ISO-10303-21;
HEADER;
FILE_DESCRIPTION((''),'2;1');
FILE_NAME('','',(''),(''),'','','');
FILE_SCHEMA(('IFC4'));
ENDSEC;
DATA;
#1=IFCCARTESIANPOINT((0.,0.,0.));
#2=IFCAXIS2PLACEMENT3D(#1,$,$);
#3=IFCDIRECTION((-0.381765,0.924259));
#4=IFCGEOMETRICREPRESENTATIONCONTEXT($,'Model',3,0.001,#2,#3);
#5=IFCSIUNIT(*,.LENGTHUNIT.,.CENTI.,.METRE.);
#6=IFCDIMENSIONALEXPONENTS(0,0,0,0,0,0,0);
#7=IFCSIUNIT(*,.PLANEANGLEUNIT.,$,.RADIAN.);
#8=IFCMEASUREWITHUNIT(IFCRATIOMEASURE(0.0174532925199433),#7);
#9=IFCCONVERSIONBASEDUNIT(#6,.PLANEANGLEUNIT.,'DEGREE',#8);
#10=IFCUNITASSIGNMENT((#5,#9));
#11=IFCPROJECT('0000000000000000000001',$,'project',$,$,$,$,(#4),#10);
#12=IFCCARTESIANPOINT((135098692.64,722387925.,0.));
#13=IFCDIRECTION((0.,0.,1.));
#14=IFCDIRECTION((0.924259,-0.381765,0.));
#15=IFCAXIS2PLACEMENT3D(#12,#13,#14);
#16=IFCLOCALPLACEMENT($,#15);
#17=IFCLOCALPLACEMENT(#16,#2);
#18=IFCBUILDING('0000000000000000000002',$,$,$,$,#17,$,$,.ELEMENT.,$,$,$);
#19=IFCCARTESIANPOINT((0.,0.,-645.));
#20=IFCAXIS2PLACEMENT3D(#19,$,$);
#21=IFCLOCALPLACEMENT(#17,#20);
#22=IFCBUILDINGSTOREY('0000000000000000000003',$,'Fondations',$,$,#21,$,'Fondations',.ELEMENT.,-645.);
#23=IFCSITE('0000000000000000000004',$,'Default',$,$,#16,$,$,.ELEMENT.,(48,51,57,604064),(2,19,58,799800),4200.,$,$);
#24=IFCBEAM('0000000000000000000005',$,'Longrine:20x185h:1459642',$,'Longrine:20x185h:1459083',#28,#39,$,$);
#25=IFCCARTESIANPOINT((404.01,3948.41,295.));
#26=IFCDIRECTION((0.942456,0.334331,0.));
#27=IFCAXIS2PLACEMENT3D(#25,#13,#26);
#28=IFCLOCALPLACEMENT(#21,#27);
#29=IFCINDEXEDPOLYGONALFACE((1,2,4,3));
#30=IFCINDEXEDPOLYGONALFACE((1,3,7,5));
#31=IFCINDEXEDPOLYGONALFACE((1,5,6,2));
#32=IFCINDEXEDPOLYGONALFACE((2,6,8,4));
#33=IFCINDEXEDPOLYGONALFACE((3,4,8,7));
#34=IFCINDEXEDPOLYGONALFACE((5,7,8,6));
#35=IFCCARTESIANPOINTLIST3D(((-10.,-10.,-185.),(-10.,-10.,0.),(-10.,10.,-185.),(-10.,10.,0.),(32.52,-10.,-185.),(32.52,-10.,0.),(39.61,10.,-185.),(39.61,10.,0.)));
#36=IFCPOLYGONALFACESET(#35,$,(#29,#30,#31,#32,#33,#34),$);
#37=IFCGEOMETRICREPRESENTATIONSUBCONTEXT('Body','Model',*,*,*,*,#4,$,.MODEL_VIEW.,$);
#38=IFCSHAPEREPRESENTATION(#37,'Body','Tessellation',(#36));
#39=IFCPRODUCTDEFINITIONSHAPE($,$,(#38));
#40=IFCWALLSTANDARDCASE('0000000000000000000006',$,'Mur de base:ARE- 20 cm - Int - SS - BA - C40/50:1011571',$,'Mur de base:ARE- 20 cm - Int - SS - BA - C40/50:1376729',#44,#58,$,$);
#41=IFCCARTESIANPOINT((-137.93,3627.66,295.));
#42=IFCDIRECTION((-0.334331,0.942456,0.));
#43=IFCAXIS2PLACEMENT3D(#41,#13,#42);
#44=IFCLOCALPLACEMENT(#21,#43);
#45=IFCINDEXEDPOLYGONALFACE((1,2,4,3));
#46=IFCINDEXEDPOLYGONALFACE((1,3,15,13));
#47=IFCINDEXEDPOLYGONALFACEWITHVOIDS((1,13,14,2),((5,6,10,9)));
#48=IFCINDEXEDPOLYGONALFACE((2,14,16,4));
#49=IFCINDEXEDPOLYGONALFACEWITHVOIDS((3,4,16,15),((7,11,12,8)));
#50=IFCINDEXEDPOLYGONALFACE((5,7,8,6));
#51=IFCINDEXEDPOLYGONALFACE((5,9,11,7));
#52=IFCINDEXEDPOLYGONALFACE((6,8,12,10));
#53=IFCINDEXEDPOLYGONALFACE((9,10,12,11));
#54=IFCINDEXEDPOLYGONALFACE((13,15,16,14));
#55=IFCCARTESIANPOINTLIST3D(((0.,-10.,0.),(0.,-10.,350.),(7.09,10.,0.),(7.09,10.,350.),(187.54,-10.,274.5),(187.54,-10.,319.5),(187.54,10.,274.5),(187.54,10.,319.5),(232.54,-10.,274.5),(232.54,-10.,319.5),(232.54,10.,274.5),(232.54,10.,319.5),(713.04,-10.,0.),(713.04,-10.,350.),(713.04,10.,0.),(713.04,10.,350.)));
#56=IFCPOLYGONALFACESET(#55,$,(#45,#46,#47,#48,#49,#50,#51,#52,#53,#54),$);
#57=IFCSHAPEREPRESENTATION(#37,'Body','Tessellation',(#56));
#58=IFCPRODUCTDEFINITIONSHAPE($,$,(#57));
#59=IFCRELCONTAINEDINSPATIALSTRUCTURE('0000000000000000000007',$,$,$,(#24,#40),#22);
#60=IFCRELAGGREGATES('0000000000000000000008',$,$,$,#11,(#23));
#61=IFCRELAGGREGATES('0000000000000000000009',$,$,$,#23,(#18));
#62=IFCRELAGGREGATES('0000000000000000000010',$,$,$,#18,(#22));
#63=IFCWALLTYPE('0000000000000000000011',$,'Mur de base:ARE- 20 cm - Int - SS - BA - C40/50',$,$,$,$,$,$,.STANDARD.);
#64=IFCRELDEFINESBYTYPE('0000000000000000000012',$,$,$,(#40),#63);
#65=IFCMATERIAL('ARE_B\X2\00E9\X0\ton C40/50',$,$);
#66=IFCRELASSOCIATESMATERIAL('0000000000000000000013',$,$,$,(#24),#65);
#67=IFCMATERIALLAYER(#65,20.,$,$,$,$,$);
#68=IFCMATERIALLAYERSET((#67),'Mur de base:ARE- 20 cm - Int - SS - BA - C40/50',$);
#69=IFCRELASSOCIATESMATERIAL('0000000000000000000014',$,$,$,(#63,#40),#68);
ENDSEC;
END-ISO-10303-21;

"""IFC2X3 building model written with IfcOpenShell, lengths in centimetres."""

from ifc_helpers import new_model, entity, si_unit, converted_unit, direction, frame, frame_2d, origin, place, context, subcontext, project, spatial, polyline, rectangle, outline, extrude, clip, halfspace, material, layer, layer_set, layer_usage, type_object, element, save


model = new_model("IFC2X3")

# Units and contexts
model_context = context("Model", 3, precision=0.001, world=origin(), true_north=direction((-0.381765, 0.924259)))
body_context = subcontext(model_context, "Body", "Model", "MODEL_VIEW")
ifc_project = project(units=[si_unit("LENGTHUNIT", "METRE", prefix="CENTI"), converted_unit("PLANEANGLEUNIT", "DEGREE", entity("IfcRatioMeasure", 0.0174532925199433), si_unit("PLANEANGLEUNIT", "RADIAN"), dimensions=[0, 0, 0, 0, 0, 0, 0])], contexts=[model_context])

# Site, building, storey
site_placement = place(None, frame((135098692.64, 722387925.0, 0.0), z_axis=(0.0, 0.0, 1.0), x_axis=(0.924259, -0.381765, 0.0)))
site = spatial("IfcSite", under=ifc_project, at=site_placement, Name="Default", CompositionType="ELEMENT", RefLatitude=(48, 51, 57, 604064), RefLongitude=(2, 19, 58, 799800), RefElevation=4200.0)
building_placement = place(site_placement, origin())
building = spatial("IfcBuilding", under=site, at=building_placement, CompositionType="ELEMENT")
storey_placement = place(building_placement, frame((0.0, 0.0, -645.0)))
storey = spatial("IfcBuildingStorey", under=building, at=storey_placement, Name="Fondations", LongName="Fondations", CompositionType="ELEMENT", Elevation=-645.0)

# Beam
ifc_material_1 = material(Name="ARE_Béton C40/50")
beam_1_placement = place(storey_placement, frame((404.01, 3948.41, 295.0), z_axis=(0.0, 0.0, 1.0), x_axis=(0.942456, 0.334331, 0.0)))
element("IfcBeam", 1, at=beam_1_placement, inside=storey, material=ifc_material_1, Name="Longrine:20x185h:1459642", ObjectType="Longrine:20x185h:1459083", context=body_context, shape_type="Clipping", body=[
    clip(extrude(rectangle(XDim=185.0, YDim=20.0, at=frame_2d((0.0, 0.0), x_axis=(1.0, 0.0))), frame((-10.0, 0.0, -92.5), z_axis=(1.0, 0.0, 0.0), x_axis=(0.0, 0.0, -1.0)), (0.0, 0.0, 1.0), 49.61), halfspace(frame((40.39, 12.2, -278.58), z_axis=(0.942456, -0.334331, 0.0), x_axis=(-0.334331, -0.942456, 0.0)), False)),
])

# Shared definitions
ifc_layer_1 = layer(ifc_material_1, 20.0)
ifc_layer_set_1 = layer_set([ifc_layer_1], Name="Mur de base:ARE- 20 cm - Int - SS - BA - C40/50")
wall_type_1 = type_object("IfcWallType", Name="Mur de base:ARE- 20 cm - Int - SS - BA - C40/50", PredefinedType="STANDARD", material=ifc_layer_set_1)

# Wall, opening
ifc_layer_usage_1 = layer_usage(ifc_layer_set_1, "AXIS2", "NEGATIVE", 10.0)
wall_1_placement = place(storey_placement, frame((-137.93, 3627.66, 295.0), z_axis=(0.0, 0.0, 1.0), x_axis=(-0.334331, 0.942456, 0.0)))
wall_1 = element("IfcWallStandardCase", 2, at=wall_1_placement, inside=storey, type_object=wall_type_1, material=ifc_layer_usage_1, Name="Mur de base:ARE- 20 cm - Int - SS - BA - C40/50:1011571", ObjectType="Mur de base:ARE- 20 cm - Int - SS - BA - C40/50:1376729", context=body_context, shape_type="SweptSolid", body=[
    extrude(outline(polyline([(713.04, -10.0), (713.04, -8.0), (713.04, 7.0), (713.04, 10.0), (693.04, 10.0), (7.09, 10.0), (0.0, -10.0), (713.04, -10.0)])), origin(), (0.0, 0.0, 1.0), 350.0),
])
opening_1_placement = place(wall_1_placement, origin())
element("IfcOpeningElement", 3, at=opening_1_placement, cuts=wall_1, ObjectType="Opening", context=body_context, shape_type="SweptSolid", body=[
    extrude(rectangle(XDim=45.0, YDim=45.0, at=frame_2d((0.0, 0.0), x_axis=(0.0, 1.0))), frame((210.04, -10.76, 297.0), z_axis=(-0.000003, 1.0, 0.0), x_axis=(1.0, 0.000003, 0.0)), (0.0, 0.0, 1.0), 21.0),
])

save(model, "model.ifc")
